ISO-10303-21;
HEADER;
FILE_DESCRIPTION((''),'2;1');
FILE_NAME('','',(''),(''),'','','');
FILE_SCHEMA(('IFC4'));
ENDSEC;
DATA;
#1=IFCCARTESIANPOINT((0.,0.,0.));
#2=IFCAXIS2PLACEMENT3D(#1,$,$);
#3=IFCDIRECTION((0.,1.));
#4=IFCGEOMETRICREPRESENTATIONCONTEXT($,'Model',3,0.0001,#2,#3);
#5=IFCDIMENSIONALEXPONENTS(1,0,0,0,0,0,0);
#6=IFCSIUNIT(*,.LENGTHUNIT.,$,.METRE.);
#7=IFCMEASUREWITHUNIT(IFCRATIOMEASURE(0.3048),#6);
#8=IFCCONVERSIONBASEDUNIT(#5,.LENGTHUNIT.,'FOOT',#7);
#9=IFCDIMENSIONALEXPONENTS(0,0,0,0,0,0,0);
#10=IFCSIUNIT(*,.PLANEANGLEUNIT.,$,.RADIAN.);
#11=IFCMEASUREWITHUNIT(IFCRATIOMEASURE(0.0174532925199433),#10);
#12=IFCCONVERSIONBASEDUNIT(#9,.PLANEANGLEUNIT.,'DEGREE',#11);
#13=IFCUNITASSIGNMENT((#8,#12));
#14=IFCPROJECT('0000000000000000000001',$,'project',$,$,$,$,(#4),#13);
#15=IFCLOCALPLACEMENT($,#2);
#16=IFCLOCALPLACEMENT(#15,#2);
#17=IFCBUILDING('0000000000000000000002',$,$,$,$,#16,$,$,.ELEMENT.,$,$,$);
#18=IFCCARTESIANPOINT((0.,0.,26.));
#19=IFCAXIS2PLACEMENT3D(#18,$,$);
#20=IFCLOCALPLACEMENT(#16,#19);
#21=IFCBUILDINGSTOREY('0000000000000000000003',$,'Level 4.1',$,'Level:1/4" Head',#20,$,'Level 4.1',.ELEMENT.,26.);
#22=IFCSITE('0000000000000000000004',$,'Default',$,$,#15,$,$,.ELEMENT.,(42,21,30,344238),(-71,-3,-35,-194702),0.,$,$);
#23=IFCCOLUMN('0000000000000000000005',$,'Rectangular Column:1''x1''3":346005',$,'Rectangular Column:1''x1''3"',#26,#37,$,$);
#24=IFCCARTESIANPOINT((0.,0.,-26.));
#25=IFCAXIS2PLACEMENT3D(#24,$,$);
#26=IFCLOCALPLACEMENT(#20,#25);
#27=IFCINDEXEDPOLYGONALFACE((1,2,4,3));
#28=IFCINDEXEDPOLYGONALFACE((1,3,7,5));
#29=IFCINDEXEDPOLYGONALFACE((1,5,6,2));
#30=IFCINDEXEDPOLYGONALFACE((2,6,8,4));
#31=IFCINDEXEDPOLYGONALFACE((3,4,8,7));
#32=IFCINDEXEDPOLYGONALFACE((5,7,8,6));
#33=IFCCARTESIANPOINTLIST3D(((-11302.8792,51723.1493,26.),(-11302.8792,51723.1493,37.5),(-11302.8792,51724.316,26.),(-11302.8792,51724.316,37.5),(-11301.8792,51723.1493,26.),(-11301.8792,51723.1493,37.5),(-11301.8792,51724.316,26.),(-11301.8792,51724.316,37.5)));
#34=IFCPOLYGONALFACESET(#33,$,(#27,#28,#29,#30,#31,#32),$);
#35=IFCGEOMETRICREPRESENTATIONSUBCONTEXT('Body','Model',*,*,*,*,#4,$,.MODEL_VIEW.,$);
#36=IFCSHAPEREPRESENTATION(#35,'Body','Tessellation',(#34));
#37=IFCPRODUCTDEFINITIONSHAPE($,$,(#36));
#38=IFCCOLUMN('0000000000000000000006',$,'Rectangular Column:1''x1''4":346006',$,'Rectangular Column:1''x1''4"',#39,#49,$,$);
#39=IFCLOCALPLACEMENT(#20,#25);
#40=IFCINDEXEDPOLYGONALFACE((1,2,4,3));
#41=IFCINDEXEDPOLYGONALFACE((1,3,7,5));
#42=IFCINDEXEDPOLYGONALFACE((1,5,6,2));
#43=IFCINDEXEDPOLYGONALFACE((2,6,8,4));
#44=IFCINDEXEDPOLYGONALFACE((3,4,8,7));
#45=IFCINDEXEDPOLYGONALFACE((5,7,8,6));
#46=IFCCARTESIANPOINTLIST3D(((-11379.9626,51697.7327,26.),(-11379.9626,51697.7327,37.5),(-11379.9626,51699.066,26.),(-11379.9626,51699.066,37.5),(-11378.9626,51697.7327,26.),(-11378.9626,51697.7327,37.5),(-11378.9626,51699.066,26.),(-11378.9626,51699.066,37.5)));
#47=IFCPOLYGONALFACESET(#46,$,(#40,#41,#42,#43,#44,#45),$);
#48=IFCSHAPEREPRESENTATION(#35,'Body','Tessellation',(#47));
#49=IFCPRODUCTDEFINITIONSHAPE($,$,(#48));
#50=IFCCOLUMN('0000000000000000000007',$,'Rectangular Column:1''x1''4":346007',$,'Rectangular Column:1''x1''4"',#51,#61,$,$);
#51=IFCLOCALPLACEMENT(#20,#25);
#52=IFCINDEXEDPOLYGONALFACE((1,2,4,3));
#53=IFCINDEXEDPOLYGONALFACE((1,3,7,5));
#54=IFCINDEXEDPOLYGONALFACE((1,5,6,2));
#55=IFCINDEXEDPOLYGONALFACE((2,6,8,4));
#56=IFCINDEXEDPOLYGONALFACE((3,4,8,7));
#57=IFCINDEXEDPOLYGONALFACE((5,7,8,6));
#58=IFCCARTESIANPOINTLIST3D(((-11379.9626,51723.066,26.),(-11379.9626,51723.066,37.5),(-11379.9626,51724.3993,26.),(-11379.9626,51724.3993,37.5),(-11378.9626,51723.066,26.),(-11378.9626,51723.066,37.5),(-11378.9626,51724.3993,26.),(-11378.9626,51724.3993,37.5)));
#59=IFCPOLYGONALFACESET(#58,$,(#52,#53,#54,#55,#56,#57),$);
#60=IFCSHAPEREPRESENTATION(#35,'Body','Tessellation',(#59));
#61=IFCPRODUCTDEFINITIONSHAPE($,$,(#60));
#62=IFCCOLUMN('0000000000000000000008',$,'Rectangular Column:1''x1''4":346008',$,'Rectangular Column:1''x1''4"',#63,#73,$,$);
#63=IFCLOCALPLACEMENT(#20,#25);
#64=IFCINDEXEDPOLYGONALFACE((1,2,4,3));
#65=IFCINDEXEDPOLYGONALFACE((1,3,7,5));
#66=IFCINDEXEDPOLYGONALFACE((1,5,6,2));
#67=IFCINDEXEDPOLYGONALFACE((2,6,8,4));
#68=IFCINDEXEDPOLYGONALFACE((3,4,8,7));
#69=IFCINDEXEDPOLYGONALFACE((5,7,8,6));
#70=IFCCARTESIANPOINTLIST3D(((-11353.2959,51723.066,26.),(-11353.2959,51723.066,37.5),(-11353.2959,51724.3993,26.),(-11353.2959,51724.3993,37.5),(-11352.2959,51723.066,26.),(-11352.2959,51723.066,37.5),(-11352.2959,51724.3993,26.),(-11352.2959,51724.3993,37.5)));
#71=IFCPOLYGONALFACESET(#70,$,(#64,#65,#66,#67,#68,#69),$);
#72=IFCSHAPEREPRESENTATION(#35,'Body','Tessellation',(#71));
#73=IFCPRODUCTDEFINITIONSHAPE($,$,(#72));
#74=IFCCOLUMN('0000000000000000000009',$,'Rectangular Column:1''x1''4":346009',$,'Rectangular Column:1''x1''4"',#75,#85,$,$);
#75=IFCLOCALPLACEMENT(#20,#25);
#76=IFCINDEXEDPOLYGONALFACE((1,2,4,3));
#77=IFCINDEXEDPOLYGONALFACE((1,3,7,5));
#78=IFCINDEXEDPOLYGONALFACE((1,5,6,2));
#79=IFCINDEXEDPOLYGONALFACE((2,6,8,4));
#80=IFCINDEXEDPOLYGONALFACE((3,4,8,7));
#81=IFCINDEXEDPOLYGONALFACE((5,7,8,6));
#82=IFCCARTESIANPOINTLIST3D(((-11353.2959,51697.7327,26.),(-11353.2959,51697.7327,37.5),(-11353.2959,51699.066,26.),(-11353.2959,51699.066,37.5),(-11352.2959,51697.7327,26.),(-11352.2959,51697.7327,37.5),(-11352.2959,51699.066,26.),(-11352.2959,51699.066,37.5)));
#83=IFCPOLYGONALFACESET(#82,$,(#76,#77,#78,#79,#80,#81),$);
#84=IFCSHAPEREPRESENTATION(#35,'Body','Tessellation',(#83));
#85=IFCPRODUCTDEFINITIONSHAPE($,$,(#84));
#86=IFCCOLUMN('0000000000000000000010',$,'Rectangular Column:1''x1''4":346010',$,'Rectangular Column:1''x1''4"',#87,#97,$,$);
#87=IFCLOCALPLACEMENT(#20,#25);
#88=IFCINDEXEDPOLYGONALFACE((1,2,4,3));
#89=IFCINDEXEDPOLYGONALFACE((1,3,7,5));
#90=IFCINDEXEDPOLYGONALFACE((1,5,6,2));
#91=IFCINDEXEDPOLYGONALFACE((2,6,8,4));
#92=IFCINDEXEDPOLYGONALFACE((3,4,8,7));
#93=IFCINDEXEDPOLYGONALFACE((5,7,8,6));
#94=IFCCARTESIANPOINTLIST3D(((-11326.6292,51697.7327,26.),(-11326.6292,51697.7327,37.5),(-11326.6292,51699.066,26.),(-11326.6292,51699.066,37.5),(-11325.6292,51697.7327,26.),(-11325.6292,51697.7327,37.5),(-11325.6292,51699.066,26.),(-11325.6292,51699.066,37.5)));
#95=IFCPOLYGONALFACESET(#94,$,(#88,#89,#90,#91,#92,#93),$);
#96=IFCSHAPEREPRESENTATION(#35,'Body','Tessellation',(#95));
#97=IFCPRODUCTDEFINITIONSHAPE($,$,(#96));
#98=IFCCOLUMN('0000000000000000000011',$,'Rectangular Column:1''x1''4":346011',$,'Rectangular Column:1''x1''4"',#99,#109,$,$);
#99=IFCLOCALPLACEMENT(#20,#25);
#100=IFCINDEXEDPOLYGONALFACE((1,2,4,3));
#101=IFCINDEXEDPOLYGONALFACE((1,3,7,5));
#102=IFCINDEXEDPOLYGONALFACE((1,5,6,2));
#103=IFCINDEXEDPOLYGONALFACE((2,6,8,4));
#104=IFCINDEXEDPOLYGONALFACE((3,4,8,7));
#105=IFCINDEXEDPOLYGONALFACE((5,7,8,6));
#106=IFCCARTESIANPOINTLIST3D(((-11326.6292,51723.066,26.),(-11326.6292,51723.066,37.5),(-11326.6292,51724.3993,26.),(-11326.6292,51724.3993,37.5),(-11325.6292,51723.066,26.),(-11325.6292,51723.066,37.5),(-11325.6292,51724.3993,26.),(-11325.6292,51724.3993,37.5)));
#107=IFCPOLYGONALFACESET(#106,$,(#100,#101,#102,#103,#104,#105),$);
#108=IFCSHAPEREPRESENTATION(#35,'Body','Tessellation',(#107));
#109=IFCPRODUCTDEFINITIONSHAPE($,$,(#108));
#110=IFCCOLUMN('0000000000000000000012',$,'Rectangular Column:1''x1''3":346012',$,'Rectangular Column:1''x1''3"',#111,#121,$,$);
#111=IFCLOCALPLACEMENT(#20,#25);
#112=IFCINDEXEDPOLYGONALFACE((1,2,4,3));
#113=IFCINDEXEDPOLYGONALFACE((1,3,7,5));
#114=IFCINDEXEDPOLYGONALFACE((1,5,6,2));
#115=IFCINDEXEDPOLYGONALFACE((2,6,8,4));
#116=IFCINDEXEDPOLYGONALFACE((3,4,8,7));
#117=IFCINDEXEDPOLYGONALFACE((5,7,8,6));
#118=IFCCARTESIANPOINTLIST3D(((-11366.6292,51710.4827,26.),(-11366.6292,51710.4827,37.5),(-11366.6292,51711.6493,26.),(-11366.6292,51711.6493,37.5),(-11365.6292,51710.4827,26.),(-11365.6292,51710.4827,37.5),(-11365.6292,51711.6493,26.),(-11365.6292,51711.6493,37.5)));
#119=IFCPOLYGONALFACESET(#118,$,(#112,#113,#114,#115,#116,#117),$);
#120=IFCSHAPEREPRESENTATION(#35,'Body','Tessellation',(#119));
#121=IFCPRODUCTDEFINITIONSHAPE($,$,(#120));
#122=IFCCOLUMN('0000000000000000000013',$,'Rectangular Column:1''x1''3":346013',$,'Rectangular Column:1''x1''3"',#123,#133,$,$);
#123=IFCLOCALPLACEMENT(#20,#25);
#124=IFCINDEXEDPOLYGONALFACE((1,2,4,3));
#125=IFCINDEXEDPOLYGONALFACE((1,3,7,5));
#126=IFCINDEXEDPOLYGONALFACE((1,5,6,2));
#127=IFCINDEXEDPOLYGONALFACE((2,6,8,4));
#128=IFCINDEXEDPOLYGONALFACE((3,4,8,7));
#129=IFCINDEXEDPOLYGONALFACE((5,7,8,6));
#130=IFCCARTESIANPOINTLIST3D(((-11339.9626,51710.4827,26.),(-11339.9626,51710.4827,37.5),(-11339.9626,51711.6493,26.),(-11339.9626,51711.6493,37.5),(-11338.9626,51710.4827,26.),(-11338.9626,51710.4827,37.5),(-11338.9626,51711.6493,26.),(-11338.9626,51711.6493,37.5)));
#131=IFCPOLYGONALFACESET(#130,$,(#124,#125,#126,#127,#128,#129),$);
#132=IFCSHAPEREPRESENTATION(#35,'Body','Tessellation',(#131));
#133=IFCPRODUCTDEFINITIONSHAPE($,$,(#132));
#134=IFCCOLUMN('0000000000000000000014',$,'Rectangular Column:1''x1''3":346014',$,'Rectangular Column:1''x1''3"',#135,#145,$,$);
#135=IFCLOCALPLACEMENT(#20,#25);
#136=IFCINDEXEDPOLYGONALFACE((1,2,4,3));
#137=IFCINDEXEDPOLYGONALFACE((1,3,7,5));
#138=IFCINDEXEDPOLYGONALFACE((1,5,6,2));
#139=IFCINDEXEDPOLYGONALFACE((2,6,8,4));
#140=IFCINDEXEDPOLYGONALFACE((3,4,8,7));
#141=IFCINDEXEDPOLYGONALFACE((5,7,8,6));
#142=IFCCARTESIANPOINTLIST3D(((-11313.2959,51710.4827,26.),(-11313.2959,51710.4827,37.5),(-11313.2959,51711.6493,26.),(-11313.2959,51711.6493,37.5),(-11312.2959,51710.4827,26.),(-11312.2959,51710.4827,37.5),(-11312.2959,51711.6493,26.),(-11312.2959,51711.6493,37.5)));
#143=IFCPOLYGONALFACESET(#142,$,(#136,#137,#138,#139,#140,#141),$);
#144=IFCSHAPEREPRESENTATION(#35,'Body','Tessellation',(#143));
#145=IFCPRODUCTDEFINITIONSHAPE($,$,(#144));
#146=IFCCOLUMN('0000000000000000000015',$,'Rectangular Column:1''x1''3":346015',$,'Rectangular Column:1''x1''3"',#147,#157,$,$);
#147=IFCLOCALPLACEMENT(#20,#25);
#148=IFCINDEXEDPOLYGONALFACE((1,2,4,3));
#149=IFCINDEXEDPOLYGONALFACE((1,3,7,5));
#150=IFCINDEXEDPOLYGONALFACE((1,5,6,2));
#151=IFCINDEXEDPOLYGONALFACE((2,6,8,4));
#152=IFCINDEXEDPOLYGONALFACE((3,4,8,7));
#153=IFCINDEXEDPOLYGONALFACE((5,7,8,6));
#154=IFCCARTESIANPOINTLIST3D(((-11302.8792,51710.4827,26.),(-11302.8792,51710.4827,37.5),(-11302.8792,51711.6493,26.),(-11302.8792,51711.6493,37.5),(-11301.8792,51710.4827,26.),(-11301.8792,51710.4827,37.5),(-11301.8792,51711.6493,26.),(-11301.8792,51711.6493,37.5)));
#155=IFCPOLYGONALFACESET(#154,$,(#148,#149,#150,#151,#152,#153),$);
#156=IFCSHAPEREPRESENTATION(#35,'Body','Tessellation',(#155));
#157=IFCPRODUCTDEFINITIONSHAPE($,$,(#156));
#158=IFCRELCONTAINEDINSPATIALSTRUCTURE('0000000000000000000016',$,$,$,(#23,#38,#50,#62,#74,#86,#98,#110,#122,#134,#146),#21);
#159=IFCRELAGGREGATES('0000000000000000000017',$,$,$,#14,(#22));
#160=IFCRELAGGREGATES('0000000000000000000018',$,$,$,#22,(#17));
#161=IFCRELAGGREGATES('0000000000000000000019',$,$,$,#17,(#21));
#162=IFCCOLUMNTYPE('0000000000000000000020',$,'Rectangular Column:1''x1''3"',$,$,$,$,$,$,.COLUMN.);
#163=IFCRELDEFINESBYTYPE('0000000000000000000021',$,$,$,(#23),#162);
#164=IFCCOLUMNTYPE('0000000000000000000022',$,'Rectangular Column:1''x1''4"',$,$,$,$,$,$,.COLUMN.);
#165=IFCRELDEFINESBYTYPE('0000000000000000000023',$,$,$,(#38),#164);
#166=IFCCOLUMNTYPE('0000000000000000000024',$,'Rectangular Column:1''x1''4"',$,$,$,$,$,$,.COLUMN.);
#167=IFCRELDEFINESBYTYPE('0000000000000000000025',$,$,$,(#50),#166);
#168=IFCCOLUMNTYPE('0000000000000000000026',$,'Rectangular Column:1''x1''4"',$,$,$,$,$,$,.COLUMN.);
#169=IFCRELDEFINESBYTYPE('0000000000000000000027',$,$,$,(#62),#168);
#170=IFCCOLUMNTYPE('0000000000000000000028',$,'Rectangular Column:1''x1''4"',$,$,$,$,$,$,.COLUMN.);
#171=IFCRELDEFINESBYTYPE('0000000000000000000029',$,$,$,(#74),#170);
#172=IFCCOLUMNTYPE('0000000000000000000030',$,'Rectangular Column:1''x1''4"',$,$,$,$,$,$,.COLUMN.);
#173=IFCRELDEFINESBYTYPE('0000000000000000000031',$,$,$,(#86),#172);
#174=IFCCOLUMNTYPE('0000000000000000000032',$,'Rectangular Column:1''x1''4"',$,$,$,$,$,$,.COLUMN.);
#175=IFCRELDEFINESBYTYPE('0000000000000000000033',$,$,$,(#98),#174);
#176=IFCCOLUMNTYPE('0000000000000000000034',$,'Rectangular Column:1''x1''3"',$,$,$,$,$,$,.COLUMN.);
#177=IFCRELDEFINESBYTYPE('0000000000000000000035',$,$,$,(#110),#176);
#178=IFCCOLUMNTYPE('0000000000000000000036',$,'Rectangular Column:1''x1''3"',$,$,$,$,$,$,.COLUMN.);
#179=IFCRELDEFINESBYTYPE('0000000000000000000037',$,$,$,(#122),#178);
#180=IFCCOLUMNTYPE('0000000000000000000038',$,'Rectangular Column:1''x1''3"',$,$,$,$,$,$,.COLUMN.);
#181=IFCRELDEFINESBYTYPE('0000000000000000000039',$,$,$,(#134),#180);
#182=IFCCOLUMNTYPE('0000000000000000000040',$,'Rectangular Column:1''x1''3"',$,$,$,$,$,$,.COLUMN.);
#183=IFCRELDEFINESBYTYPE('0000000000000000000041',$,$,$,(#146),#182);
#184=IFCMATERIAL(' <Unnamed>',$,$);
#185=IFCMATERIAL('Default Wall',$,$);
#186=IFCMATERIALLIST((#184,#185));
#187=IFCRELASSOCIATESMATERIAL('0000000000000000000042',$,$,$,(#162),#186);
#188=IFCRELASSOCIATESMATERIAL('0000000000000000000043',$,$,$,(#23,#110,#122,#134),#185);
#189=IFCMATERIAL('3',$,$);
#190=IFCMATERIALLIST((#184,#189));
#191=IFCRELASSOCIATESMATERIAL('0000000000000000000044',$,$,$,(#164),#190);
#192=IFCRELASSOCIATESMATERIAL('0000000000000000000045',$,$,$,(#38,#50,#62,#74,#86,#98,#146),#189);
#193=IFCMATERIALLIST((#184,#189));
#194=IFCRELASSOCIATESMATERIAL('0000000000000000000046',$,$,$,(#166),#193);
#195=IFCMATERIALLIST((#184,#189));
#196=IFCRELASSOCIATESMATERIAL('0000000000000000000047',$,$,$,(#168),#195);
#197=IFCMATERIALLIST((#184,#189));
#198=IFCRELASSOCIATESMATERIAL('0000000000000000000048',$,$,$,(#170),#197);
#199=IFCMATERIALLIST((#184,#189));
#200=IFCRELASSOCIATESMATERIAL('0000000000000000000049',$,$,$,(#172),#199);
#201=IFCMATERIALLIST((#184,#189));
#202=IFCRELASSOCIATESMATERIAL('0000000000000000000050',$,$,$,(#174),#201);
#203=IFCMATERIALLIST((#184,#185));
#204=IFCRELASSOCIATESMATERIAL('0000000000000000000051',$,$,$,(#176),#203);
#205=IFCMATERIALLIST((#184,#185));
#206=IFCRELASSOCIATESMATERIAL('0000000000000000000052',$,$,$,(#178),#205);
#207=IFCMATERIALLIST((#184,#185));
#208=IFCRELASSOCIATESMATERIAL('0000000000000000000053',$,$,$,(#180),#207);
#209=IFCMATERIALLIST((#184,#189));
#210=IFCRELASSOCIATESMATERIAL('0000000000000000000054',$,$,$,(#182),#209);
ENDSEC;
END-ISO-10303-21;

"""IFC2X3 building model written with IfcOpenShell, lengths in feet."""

from ifc_helpers import new_model, entity, si_unit, converted_unit, direction, frame, frame_2d, origin, place, context, subcontext, project, spatial, rectangle, extrude, source, transform, mapped, material, material_list, type_object, type_shapes, element, save


model = new_model("IFC2X3")

# Units and contexts
model_context = context("Model", 3, precision=0.0001, world=origin(), true_north=direction((0.0, 1.0)))
body_context = subcontext(model_context, "Body", "Model", "MODEL_VIEW")
ifc_project = project(units=[converted_unit("LENGTHUNIT", "FOOT", entity("IfcRatioMeasure", 0.3048), si_unit("LENGTHUNIT", "METRE"), dimensions=[1, 0, 0, 0, 0, 0, 0]), converted_unit("PLANEANGLEUNIT", "DEGREE", entity("IfcRatioMeasure", 0.0174532925199433), si_unit("PLANEANGLEUNIT", "RADIAN"), dimensions=[0, 0, 0, 0, 0, 0, 0])], contexts=[model_context])

# Site, building, storey
site_placement = place(None, origin())
site = spatial("IfcSite", under=ifc_project, at=site_placement, Name="Default", CompositionType="ELEMENT", RefLatitude=(42, 21, 30, 344238), RefLongitude=(-71, -3, -35, -194702), RefElevation=0.0)
building_placement = place(site_placement, origin())
building = spatial("IfcBuilding", under=site, at=building_placement, CompositionType="ELEMENT")
storey_placement = place(building_placement, frame((0.0, 0.0, 26.0)))
storey = spatial("IfcBuildingStorey", under=building, at=storey_placement, Name="Level 4.1", ObjectType="Level:1/4\" Head", LongName="Level 4.1", CompositionType="ELEMENT", Elevation=26.0)

# Columns
ifc_material_1 = material(Name="Default Wall")
ifc_material_2 = material(Name=" <Unnamed>")
ifc_material_list_1 = material_list([ifc_material_2, ifc_material_1])
column_type_1 = type_object("IfcColumnType", Name="Rectangular Column:1'x1'3\"", PredefinedType="COLUMN", material=ifc_material_list_1)
shared_shape_1 = source(origin(), body_context, "Body", "SweptSolid", [
    extrude(rectangle(XDim=1.1667, YDim=1.0, at=frame_2d((0.0, 0.0), x_axis=(1.0, 0.0))), frame((-11302.3792, 51723.7327, 26.0), z_axis=(0.0, 0.0, 1.0), x_axis=(0.0, -1.0, 0.0)), (0.0, 0.0, 1.0), 11.5),
])
type_shapes(column_type_1, [shared_shape_1])
column_1_placement = place(storey_placement, frame((0.0, 0.0, -26.0)))
element("IfcColumn", 1, at=column_1_placement, inside=storey, type_object=column_type_1, material=ifc_material_1, Name="Rectangular Column:1'x1'3\":346005", ObjectType="Rectangular Column:1'x1'3\"", context=body_context, shape_type="MappedRepresentation", body=[
    mapped(shared_shape_1, transform((0.0, 0.0, 0.0), scale=1.0)),
])
ifc_material_3 = material(Name="3")
ifc_material_list_2 = material_list([ifc_material_2, ifc_material_3])
column_type_2 = type_object("IfcColumnType", Name="Rectangular Column:1'x1'4\"", PredefinedType="COLUMN", material=ifc_material_list_2)
shared_shape_2 = source(origin(), body_context, "Body", "SweptSolid", [
    extrude(rectangle(XDim=1.3333, YDim=1.0, at=frame_2d((0.0, 0.0), x_axis=(1.0, 0.0))), frame((-11379.4626, 51698.3993, 26.0), z_axis=(0.0, 0.0, 1.0), x_axis=(0.0, -1.0, 0.0)), (0.0, 0.0, 1.0), 11.5),
])
type_shapes(column_type_2, [shared_shape_2])
column_2_placement = place(storey_placement, frame((0.0, 0.0, -26.0)))
element("IfcColumn", 2, at=column_2_placement, inside=storey, type_object=column_type_2, material=ifc_material_3, Name="Rectangular Column:1'x1'4\":346006", ObjectType="Rectangular Column:1'x1'4\"", context=body_context, shape_type="MappedRepresentation", body=[
    mapped(shared_shape_2, transform((0.0, 0.0, 0.0), scale=1.0)),
])
ifc_material_list_3 = material_list([ifc_material_2, ifc_material_3])
column_type_3 = type_object("IfcColumnType", Name="Rectangular Column:1'x1'4\"", PredefinedType="COLUMN", material=ifc_material_list_3)
shared_shape_3 = source(origin(), body_context, "Body", "SweptSolid", [
    extrude(rectangle(XDim=1.3333, YDim=1.0, at=frame_2d((0.0, 0.0), x_axis=(1.0, 0.0))), frame((-11379.4626, 51723.7327, 26.0), z_axis=(0.0, 0.0, 1.0), x_axis=(0.0, -1.0, 0.0)), (0.0, 0.0, 1.0), 11.5),
])
type_shapes(column_type_3, [shared_shape_3])
column_3_placement = place(storey_placement, frame((0.0, 0.0, -26.0)))
element("IfcColumn", 3, at=column_3_placement, inside=storey, type_object=column_type_3, material=ifc_material_3, Name="Rectangular Column:1'x1'4\":346007", ObjectType="Rectangular Column:1'x1'4\"", context=body_context, shape_type="MappedRepresentation", body=[
    mapped(shared_shape_3, transform((0.0, 0.0, 0.0), scale=1.0)),
])
ifc_material_list_4 = material_list([ifc_material_2, ifc_material_3])
column_type_4 = type_object("IfcColumnType", Name="Rectangular Column:1'x1'4\"", PredefinedType="COLUMN", material=ifc_material_list_4)
shared_shape_4 = source(origin(), body_context, "Body", "SweptSolid", [
    extrude(rectangle(XDim=1.3333, YDim=1.0, at=frame_2d((0.0, 0.0), x_axis=(1.0, 0.0))), frame((-11352.7959, 51723.7327, 26.0), z_axis=(0.0, 0.0, 1.0), x_axis=(0.0, -1.0, 0.0)), (0.0, 0.0, 1.0), 11.5),
])
type_shapes(column_type_4, [shared_shape_4])
column_4_placement = place(storey_placement, frame((0.0, 0.0, -26.0)))
element("IfcColumn", 4, at=column_4_placement, inside=storey, type_object=column_type_4, material=ifc_material_3, Name="Rectangular Column:1'x1'4\":346008", ObjectType="Rectangular Column:1'x1'4\"", context=body_context, shape_type="MappedRepresentation", body=[
    mapped(shared_shape_4, transform((0.0, 0.0, 0.0), scale=1.0)),
])
ifc_material_list_5 = material_list([ifc_material_2, ifc_material_3])
column_type_5 = type_object("IfcColumnType", Name="Rectangular Column:1'x1'4\"", PredefinedType="COLUMN", material=ifc_material_list_5)
shared_shape_5 = source(origin(), body_context, "Body", "SweptSolid", [
    extrude(rectangle(XDim=1.3333, YDim=1.0, at=frame_2d((0.0, 0.0), x_axis=(1.0, 0.0))), frame((-11352.7959, 51698.3993, 26.0), z_axis=(0.0, 0.0, 1.0), x_axis=(0.0, -1.0, 0.0)), (0.0, 0.0, 1.0), 11.5),
])
type_shapes(column_type_5, [shared_shape_5])
column_5_placement = place(storey_placement, frame((0.0, 0.0, -26.0)))
element("IfcColumn", 5, at=column_5_placement, inside=storey, type_object=column_type_5, material=ifc_material_3, Name="Rectangular Column:1'x1'4\":346009", ObjectType="Rectangular Column:1'x1'4\"", context=body_context, shape_type="MappedRepresentation", body=[
    mapped(shared_shape_5, transform((0.0, 0.0, 0.0), scale=1.0)),
])
ifc_material_list_6 = material_list([ifc_material_2, ifc_material_3])
column_type_6 = type_object("IfcColumnType", Name="Rectangular Column:1'x1'4\"", PredefinedType="COLUMN", material=ifc_material_list_6)
shared_shape_6 = source(origin(), body_context, "Body", "SweptSolid", [
    extrude(rectangle(XDim=1.3333, YDim=1.0, at=frame_2d((0.0, 0.0), x_axis=(1.0, 0.0))), frame((-11326.1292, 51698.3993, 26.0), z_axis=(0.0, 0.0, 1.0), x_axis=(0.0, -1.0, 0.0)), (0.0, 0.0, 1.0), 11.5),
])
type_shapes(column_type_6, [shared_shape_6])
column_6_placement = place(storey_placement, frame((0.0, 0.0, -26.0)))
element("IfcColumn", 6, at=column_6_placement, inside=storey, type_object=column_type_6, material=ifc_material_3, Name="Rectangular Column:1'x1'4\":346010", ObjectType="Rectangular Column:1'x1'4\"", context=body_context, shape_type="MappedRepresentation", body=[
    mapped(shared_shape_6, transform((0.0, 0.0, 0.0), scale=1.0)),
])
ifc_material_list_7 = material_list([ifc_material_2, ifc_material_3])
column_type_7 = type_object("IfcColumnType", Name="Rectangular Column:1'x1'4\"", PredefinedType="COLUMN", material=ifc_material_list_7)
shared_shape_7 = source(origin(), body_context, "Body", "SweptSolid", [
    extrude(rectangle(XDim=1.3333, YDim=1.0, at=frame_2d((0.0, 0.0), x_axis=(1.0, 0.0))), frame((-11326.1292, 51723.7327, 26.0), z_axis=(0.0, 0.0, 1.0), x_axis=(0.0, -1.0, 0.0)), (0.0, 0.0, 1.0), 11.5),
])
type_shapes(column_type_7, [shared_shape_7])
column_7_placement = place(storey_placement, frame((0.0, 0.0, -26.0)))
element("IfcColumn", 7, at=column_7_placement, inside=storey, type_object=column_type_7, material=ifc_material_3, Name="Rectangular Column:1'x1'4\":346011", ObjectType="Rectangular Column:1'x1'4\"", context=body_context, shape_type="MappedRepresentation", body=[
    mapped(shared_shape_7, transform((0.0, 0.0, 0.0), scale=1.0)),
])
ifc_material_list_8 = material_list([ifc_material_2, ifc_material_1])
column_type_8 = type_object("IfcColumnType", Name="Rectangular Column:1'x1'3\"", PredefinedType="COLUMN", material=ifc_material_list_8)
shared_shape_8 = source(origin(), body_context, "Body", "SweptSolid", [
    extrude(rectangle(XDim=1.1667, YDim=1.0, at=frame_2d((0.0, 0.0), x_axis=(1.0, 0.0))), frame((-11366.1292, 51711.066, 26.0), z_axis=(0.0, 0.0, 1.0), x_axis=(0.0, -1.0, 0.0)), (0.0, 0.0, 1.0), 11.5),
])
type_shapes(column_type_8, [shared_shape_8])
column_8_placement = place(storey_placement, frame((0.0, 0.0, -26.0)))
element("IfcColumn", 8, at=column_8_placement, inside=storey, type_object=column_type_8, material=ifc_material_1, Name="Rectangular Column:1'x1'3\":346012", ObjectType="Rectangular Column:1'x1'3\"", context=body_context, shape_type="MappedRepresentation", body=[
    mapped(shared_shape_8, transform((0.0, 0.0, 0.0), scale=1.0)),
])
ifc_material_list_9 = material_list([ifc_material_2, ifc_material_1])
column_type_9 = type_object("IfcColumnType", Name="Rectangular Column:1'x1'3\"", PredefinedType="COLUMN", material=ifc_material_list_9)
shared_shape_9 = source(origin(), body_context, "Body", "SweptSolid", [
    extrude(rectangle(XDim=1.1667, YDim=1.0, at=frame_2d((0.0, 0.0), x_axis=(1.0, 0.0))), frame((-11339.4626, 51711.066, 26.0), z_axis=(0.0, 0.0, 1.0), x_axis=(0.0, -1.0, 0.0)), (0.0, 0.0, 1.0), 11.5),
])
type_shapes(column_type_9, [shared_shape_9])
column_9_placement = place(storey_placement, frame((0.0, 0.0, -26.0)))
element("IfcColumn", 9, at=column_9_placement, inside=storey, type_object=column_type_9, material=ifc_material_1, Name="Rectangular Column:1'x1'3\":346013", ObjectType="Rectangular Column:1'x1'3\"", context=body_context, shape_type="MappedRepresentation", body=[
    mapped(shared_shape_9, transform((0.0, 0.0, 0.0), scale=1.0)),
])
ifc_material_list_10 = material_list([ifc_material_2, ifc_material_1])
column_type_10 = type_object("IfcColumnType", Name="Rectangular Column:1'x1'3\"", PredefinedType="COLUMN", material=ifc_material_list_10)
shared_shape_10 = source(origin(), body_context, "Body", "SweptSolid", [
    extrude(rectangle(XDim=1.1667, YDim=1.0, at=frame_2d((0.0, 0.0), x_axis=(1.0, 0.0))), frame((-11312.7959, 51711.066, 26.0), z_axis=(0.0, 0.0, 1.0), x_axis=(0.0, -1.0, 0.0)), (0.0, 0.0, 1.0), 11.5),
])
type_shapes(column_type_10, [shared_shape_10])
column_10_placement = place(storey_placement, frame((0.0, 0.0, -26.0)))
element("IfcColumn", 10, at=column_10_placement, inside=storey, type_object=column_type_10, material=ifc_material_1, Name="Rectangular Column:1'x1'3\":346014", ObjectType="Rectangular Column:1'x1'3\"", context=body_context, shape_type="MappedRepresentation", body=[
    mapped(shared_shape_10, transform((0.0, 0.0, 0.0), scale=1.0)),
])
ifc_material_list_11 = material_list([ifc_material_2, ifc_material_3])
column_type_11 = type_object("IfcColumnType", Name="Rectangular Column:1'x1'3\"", PredefinedType="COLUMN", material=ifc_material_list_11)
shared_shape_11 = source(origin(), body_context, "Body", "SweptSolid", [
    extrude(rectangle(XDim=1.1667, YDim=1.0, at=frame_2d((0.0, 0.0), x_axis=(1.0, 0.0))), frame((-11302.3792, 51711.066, 26.0), z_axis=(0.0, 0.0, 1.0), x_axis=(0.0, -1.0, 0.0)), (0.0, 0.0, 1.0), 11.5),
])
type_shapes(column_type_11, [shared_shape_11])
column_11_placement = place(storey_placement, frame((0.0, 0.0, -26.0)))
element("IfcColumn", 11, at=column_11_placement, inside=storey, type_object=column_type_11, material=ifc_material_3, Name="Rectangular Column:1'x1'3\":346015", ObjectType="Rectangular Column:1'x1'3\"", context=body_context, shape_type="MappedRepresentation", body=[
    mapped(shared_shape_11, transform((0.0, 0.0, 0.0), scale=1.0)),
])

save(model, "model.ifc")
